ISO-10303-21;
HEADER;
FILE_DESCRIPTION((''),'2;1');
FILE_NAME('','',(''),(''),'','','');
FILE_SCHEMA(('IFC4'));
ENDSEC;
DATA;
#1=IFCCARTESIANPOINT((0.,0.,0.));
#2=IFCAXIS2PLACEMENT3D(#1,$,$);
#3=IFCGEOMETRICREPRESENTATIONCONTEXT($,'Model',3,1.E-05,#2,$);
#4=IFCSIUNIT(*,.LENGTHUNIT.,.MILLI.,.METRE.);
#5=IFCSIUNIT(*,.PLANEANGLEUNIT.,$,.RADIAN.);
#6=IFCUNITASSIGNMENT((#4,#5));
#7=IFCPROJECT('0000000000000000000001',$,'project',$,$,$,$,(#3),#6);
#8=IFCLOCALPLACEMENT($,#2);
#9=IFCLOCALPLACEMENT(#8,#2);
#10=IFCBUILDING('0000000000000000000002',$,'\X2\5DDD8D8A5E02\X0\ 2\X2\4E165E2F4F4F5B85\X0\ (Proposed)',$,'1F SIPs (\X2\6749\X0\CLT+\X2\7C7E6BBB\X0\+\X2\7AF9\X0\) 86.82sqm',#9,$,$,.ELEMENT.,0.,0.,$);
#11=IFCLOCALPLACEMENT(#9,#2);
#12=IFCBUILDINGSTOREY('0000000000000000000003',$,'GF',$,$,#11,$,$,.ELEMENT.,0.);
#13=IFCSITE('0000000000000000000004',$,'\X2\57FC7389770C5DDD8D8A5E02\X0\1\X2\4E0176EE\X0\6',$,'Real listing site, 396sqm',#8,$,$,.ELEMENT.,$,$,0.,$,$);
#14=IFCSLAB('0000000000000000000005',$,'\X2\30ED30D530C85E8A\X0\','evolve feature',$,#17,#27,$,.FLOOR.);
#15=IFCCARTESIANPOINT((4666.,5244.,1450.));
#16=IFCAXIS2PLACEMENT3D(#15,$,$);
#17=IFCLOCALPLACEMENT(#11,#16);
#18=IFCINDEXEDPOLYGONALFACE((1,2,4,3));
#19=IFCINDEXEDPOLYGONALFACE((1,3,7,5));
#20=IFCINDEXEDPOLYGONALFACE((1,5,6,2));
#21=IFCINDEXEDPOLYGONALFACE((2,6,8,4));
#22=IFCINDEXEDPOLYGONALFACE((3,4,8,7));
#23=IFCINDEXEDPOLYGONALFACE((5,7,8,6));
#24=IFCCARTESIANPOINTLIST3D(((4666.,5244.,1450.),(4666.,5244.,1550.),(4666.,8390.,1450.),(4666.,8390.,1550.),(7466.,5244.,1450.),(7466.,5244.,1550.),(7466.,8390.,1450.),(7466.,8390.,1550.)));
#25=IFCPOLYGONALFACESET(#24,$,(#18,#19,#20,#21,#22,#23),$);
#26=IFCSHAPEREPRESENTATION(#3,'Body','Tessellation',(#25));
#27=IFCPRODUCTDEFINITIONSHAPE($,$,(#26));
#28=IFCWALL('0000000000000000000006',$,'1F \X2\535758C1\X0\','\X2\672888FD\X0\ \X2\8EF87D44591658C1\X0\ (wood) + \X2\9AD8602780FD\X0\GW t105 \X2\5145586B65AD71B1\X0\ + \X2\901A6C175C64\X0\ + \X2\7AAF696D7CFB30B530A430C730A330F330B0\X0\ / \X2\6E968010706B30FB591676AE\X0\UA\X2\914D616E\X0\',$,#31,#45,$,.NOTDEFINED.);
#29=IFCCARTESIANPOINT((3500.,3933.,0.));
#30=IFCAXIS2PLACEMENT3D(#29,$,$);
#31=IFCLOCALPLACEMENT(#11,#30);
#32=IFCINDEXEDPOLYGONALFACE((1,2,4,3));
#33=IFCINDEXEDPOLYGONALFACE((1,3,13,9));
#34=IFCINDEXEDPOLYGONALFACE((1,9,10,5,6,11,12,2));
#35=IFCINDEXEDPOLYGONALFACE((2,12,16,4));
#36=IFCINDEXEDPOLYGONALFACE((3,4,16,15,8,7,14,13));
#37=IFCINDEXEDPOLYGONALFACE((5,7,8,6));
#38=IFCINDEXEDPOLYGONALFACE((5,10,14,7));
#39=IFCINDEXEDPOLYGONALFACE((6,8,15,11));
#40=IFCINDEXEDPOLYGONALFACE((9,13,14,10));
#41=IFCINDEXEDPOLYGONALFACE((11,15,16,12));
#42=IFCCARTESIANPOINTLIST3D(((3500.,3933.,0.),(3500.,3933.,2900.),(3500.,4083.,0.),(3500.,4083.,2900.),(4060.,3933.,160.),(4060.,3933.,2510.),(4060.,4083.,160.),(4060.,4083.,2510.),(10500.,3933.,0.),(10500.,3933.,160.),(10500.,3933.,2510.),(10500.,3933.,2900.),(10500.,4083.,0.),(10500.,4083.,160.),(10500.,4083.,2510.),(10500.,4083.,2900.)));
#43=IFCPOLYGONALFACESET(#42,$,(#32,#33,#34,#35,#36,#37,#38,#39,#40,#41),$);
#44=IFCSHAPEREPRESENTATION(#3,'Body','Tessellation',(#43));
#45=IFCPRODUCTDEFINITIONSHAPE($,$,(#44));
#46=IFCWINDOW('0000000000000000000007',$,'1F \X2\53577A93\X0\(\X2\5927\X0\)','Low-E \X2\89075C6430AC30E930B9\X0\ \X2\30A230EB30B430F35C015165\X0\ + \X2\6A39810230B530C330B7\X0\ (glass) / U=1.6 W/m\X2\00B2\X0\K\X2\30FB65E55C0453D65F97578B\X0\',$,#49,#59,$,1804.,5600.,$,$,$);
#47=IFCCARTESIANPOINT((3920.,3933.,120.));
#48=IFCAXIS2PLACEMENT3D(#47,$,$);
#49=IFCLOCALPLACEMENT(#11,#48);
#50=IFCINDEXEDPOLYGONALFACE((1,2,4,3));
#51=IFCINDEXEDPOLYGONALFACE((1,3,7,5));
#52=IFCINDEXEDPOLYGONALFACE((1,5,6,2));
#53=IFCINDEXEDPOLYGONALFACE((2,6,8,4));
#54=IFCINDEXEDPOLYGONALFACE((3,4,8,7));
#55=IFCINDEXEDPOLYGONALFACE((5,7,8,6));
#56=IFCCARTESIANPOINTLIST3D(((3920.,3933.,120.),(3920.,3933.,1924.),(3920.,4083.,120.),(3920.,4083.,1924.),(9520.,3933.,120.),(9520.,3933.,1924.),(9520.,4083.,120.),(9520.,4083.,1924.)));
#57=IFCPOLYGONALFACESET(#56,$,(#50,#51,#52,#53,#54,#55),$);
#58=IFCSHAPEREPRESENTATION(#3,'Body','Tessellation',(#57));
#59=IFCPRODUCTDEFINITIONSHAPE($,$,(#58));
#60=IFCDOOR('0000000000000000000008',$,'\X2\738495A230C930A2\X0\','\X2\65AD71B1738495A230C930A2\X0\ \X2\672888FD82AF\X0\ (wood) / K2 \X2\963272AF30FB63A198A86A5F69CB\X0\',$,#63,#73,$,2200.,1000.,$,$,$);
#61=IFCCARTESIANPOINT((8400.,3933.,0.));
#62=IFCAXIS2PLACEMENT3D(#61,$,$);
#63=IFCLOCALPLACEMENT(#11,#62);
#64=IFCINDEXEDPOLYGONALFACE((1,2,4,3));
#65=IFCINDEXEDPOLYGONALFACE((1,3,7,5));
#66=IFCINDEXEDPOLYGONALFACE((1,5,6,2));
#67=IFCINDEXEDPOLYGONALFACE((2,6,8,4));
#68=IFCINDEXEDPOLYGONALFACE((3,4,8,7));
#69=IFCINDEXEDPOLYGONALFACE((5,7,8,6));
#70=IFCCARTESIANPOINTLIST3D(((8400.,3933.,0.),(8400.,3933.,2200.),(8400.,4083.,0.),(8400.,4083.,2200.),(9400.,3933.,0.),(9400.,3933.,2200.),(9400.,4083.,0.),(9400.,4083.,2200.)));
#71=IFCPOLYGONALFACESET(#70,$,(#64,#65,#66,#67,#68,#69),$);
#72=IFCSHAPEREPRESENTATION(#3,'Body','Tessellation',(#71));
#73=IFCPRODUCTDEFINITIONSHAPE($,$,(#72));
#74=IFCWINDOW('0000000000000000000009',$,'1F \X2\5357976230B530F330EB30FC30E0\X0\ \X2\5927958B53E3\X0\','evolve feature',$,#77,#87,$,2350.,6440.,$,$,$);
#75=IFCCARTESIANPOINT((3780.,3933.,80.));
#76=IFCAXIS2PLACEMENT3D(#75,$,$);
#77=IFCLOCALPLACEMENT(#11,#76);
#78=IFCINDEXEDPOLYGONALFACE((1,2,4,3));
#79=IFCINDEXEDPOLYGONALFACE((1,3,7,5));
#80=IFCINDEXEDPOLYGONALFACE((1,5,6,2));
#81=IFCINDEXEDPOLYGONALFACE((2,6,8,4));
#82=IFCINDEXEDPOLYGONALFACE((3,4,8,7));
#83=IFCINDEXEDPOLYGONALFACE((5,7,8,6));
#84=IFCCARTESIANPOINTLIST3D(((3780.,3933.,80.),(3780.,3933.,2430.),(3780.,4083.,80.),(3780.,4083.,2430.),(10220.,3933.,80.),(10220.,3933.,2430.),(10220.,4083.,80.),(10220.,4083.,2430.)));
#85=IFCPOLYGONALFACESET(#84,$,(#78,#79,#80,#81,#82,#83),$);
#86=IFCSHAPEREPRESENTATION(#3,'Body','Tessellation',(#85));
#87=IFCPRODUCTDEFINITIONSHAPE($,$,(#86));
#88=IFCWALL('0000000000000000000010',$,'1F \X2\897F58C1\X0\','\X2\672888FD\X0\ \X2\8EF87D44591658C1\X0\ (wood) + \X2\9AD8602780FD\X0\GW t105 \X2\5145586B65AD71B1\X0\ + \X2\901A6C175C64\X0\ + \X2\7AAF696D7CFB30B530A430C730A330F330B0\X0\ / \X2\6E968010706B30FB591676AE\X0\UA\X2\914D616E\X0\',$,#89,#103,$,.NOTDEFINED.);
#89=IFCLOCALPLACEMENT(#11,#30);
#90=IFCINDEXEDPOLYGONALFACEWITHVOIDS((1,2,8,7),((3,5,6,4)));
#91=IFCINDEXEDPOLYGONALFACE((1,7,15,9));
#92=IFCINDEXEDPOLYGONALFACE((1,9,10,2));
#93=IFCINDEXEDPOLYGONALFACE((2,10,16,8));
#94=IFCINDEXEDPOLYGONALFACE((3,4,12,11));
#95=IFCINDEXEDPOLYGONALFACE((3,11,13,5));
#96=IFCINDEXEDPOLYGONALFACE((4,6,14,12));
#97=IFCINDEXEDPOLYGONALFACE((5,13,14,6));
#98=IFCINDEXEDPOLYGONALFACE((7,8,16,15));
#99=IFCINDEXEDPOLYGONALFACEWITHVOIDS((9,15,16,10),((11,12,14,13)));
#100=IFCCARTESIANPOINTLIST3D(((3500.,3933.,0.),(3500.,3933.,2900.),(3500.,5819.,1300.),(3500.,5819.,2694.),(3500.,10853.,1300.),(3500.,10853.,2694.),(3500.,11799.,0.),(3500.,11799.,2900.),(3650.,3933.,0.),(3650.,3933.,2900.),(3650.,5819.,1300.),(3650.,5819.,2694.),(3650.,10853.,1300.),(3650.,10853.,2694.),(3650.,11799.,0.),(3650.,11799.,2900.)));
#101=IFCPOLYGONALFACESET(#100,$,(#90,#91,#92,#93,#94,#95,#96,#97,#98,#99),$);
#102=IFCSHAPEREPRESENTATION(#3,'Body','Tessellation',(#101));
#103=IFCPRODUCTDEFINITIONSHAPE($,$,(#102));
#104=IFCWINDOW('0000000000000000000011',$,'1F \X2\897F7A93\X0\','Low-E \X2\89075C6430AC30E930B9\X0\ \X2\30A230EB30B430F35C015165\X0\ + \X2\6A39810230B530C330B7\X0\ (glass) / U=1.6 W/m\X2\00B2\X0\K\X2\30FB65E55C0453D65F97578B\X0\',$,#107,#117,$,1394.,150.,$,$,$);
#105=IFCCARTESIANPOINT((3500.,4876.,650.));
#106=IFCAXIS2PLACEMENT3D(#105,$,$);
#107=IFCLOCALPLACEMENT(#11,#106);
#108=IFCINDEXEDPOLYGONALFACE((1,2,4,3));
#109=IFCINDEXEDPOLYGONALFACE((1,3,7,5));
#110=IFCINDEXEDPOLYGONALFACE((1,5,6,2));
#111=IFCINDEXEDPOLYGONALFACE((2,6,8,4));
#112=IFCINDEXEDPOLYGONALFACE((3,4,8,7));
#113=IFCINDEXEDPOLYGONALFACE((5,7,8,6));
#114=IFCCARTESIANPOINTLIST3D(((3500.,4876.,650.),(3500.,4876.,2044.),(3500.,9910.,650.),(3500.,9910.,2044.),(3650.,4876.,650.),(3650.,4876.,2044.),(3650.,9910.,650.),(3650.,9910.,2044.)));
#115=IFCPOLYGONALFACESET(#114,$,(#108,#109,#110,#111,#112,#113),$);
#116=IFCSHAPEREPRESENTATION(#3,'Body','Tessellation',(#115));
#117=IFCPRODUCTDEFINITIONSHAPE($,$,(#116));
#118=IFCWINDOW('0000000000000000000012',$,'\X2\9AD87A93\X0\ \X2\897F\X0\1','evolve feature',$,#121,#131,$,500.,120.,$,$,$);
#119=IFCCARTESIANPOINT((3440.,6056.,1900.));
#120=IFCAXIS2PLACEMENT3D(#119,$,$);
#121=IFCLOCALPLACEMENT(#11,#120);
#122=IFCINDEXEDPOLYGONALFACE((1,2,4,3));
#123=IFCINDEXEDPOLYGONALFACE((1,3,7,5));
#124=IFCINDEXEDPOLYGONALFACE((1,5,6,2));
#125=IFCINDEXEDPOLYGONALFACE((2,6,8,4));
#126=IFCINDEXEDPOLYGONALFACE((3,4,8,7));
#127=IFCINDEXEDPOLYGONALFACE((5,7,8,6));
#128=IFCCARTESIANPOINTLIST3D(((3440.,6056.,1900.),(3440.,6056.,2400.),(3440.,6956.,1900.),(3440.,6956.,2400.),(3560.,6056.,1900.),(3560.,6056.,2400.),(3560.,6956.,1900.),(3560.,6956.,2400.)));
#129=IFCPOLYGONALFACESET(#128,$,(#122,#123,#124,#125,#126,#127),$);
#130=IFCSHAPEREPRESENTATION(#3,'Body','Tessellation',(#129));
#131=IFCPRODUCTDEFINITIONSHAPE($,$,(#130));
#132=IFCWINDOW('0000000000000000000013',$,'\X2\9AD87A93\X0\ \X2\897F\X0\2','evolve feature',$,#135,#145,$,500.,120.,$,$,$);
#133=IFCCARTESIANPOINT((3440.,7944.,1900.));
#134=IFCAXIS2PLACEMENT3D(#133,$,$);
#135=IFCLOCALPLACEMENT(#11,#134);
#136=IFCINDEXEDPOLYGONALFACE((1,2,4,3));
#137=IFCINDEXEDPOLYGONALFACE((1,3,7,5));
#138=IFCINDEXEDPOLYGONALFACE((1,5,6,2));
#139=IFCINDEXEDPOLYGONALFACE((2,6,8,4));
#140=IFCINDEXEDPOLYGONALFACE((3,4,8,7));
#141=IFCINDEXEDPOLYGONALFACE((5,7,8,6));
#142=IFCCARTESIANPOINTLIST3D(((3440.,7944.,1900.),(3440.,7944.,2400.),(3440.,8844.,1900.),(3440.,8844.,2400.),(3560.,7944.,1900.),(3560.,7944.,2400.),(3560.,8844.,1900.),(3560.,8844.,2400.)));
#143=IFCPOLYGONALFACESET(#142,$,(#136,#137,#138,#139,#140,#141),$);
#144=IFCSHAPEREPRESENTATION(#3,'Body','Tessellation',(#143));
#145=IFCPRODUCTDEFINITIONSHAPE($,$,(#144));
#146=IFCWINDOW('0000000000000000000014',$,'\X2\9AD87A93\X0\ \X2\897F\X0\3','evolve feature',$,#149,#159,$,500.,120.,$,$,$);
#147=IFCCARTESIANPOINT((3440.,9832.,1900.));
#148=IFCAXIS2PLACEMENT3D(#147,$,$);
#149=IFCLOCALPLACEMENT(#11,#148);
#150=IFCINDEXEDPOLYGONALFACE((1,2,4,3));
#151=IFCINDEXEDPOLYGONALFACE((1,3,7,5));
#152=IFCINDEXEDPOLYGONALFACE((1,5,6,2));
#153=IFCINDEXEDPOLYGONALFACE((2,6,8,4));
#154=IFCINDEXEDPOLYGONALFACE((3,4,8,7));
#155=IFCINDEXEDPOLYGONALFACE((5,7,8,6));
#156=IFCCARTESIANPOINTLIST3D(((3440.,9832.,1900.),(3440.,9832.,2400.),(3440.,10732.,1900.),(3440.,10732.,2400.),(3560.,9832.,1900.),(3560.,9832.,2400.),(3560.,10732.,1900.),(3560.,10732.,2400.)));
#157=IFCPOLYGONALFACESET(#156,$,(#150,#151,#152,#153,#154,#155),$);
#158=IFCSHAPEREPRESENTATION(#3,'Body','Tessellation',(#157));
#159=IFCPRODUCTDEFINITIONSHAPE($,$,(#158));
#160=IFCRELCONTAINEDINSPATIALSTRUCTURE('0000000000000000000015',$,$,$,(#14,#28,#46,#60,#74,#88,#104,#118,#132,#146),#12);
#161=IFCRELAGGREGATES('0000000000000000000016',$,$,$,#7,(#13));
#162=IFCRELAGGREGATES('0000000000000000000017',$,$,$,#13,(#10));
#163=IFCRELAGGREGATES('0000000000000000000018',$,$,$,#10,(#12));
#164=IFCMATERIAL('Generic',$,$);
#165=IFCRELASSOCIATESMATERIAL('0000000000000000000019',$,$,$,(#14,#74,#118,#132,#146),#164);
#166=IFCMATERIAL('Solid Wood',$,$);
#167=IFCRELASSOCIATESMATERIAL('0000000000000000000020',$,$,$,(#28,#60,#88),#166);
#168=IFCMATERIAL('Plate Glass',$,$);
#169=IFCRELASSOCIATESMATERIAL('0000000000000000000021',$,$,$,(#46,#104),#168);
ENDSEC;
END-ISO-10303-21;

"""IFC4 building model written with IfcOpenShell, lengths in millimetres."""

from ifc_helpers import new_model, si_unit, frame, frame_2d, origin, place, context, project, spatial, rectangle, extrude, material, element, fill, save


model = new_model("IFC4")

# Units and contexts
model_context = context("Model", 3, precision=1e-05, world=origin())
ifc_project = project(units=[si_unit("LENGTHUNIT", "METRE", prefix="MILLI"), si_unit("PLANEANGLEUNIT", "RADIAN")], contexts=[model_context])

# Site, building, storey
site_placement = place(None, origin())
site = spatial("IfcSite", under=ifc_project, at=site_placement, Name="埼玉県川越市1丁目6", ObjectType="Real listing site, 396sqm", CompositionType="ELEMENT", RefElevation=0.0)
building_placement = place(site_placement, origin())
building = spatial("IfcBuilding", under=site, at=building_placement, Name="川越市 2世帯住宅 (Proposed)", ObjectType="1F SIPs (杉CLT+籾殻+竹) 86.82sqm", CompositionType="ELEMENT", ElevationOfRefHeight=0.0, ElevationOfTerrain=0.0)
storey_placement = place(building_placement, origin())
storey = spatial("IfcBuildingStorey", under=building, at=storey_placement, Name="GF", CompositionType="ELEMENT", Elevation=0.0)

# Slab
ifc_material_1 = material(Name="Solid Wood")
ifc_material_2 = material(Name="Generic")
slab_1_placement = place(storey_placement, frame((4666.0, 5244.0, 1450.0)))
element("IfcSlab", 1, at=slab_1_placement, inside=storey, material=ifc_material_2, Name="ロフト床", Description="evolve feature", PredefinedType="FLOOR", context=model_context, shape_type="SweptSolid", body=[
    extrude(rectangle(XDim=2800.0, YDim=3146.0, at=frame_2d((1400.0, 1573.0))), frame((4666.0, 5244.0, 1450.0)), (0.0, 0.0, 1.0), 100.0),
])

# Wall, openings, windows, door
wall_1_placement = place(storey_placement, frame((3500.0, 3933.0, 0.0)))
wall_1 = element("IfcWall", 2, at=wall_1_placement, inside=storey, material=ifc_material_1, Name="1F 南壁", Description="木製 軸組外壁 (wood) + 高性能GW t105 充填断熱 + 通気層 + 窯業系サイディング / 準耐火・外皮UA配慮", PredefinedType="NOTDEFINED", context=model_context, shape_type="SweptSolid", body=[
    extrude(rectangle(XDim=7000.0, YDim=150.0, at=frame_2d((3500.0, 75.0))), frame((3500.0, 3933.0, 0.0)), (0.0, 0.0, 1.0), 2900.0),
])
opening_1_placement = place(storey_placement, frame((3920.0, 3933.0, 120.0)))
opening_1 = element("IfcOpeningElement", 3, at=opening_1_placement, cuts=wall_1, PredefinedType="NOTDEFINED", context=model_context, shape_type="SweptSolid", body=[
    extrude(rectangle(XDim=5600.0, YDim=150.0, at=frame_2d((2800.0, 75.0))), frame((3920.0, 3933.0, 120.0)), (0.0, 0.0, 1.0), 1804.0),
])
opening_2_placement = place(storey_placement, frame((8400.0, 3933.0, 0.0)))
opening_2 = element("IfcOpeningElement", 4, at=opening_2_placement, cuts=wall_1, PredefinedType="NOTDEFINED", context=model_context, shape_type="SweptSolid", body=[
    extrude(rectangle(XDim=1000.0, YDim=150.0, at=frame_2d((500.0, 75.0))), frame((8400.0, 3933.0, 0.0)), (0.0, 0.0, 1.0), 2200.0),
])
opening_3_placement = place(storey_placement, frame((3780.0, 3933.0, 80.0)))
opening_3 = element("IfcOpeningElement", 5, at=opening_3_placement, cuts=wall_1, PredefinedType="NOTDEFINED", context=model_context, shape_type="SweptSolid", body=[
    extrude(rectangle(XDim=6440.0, YDim=150.0, at=frame_2d((3220.0, 75.0))), frame((3780.0, 3933.0, 80.0)), (0.0, 0.0, 1.0), 2350.0),
])
ifc_material_3 = material(Name="Plate Glass")
window_1_placement = place(storey_placement, frame((3920.0, 3933.0, 120.0)))
window_1 = element("IfcWindow", 6, at=window_1_placement, inside=storey, material=ifc_material_3, Name="1F 南窓(大)", Description="Low-E 複層ガラス アルゴン封入 + 樹脂サッシ (glass) / U=1.6 W/m²K・日射取得型", OverallHeight=1804.0, OverallWidth=5600.0, context=model_context, shape_type="SweptSolid", body=[
    extrude(rectangle(XDim=5600.0, YDim=150.0, at=frame_2d((2800.0, 75.0))), frame((3920.0, 3933.0, 120.0)), (0.0, 0.0, 1.0), 1804.0),
])
fill(opening_1, window_1)
door_placement = place(storey_placement, frame((8400.0, 3933.0, 0.0)))
door = element("IfcDoor", 7, at=door_placement, inside=storey, material=ifc_material_1, Name="玄関ドア", Description="断熱玄関ドア 木製芯 (wood) / K2 防犯・採風機構", OverallHeight=2200.0, OverallWidth=1000.0, context=model_context, shape_type="SweptSolid", body=[
    extrude(rectangle(XDim=1000.0, YDim=150.0, at=frame_2d((500.0, 75.0))), frame((8400.0, 3933.0, 0.0)), (0.0, 0.0, 1.0), 2200.0),
])
fill(opening_2, door)
window_2_placement = place(storey_placement, frame((3780.0, 3933.0, 80.0)))
window_2 = element("IfcWindow", 8, at=window_2_placement, inside=storey, material=ifc_material_2, Name="1F 南面サンルーム 大開口", Description="evolve feature", OverallHeight=2350.0, OverallWidth=6440.0, context=model_context, shape_type="SweptSolid", body=[
    extrude(rectangle(XDim=6440.0, YDim=150.0, at=frame_2d((3220.0, 75.0))), frame((3780.0, 3933.0, 80.0)), (0.0, 0.0, 1.0), 2350.0),
])
fill(opening_3, window_2)

# Wall, openings, windows
wall_2_placement = place(storey_placement, frame((3500.0, 3933.0, 0.0)))
wall_2 = element("IfcWall", 9, at=wall_2_placement, inside=storey, material=ifc_material_1, Name="1F 西壁", Description="木製 軸組外壁 (wood) + 高性能GW t105 充填断熱 + 通気層 + 窯業系サイディング / 準耐火・外皮UA配慮", PredefinedType="NOTDEFINED", context=model_context, shape_type="SweptSolid", body=[
    extrude(rectangle(XDim=150.0, YDim=7866.0, at=frame_2d((75.0, 3933.0))), frame((3500.0, 3933.0, 0.0)), (0.0, 0.0, 1.0), 2900.0),
])
opening_4_placement = place(storey_placement, frame((3500.0, 4876.0, 650.0)))
opening_4 = element("IfcOpeningElement", 10, at=opening_4_placement, cuts=wall_2, PredefinedType="NOTDEFINED", context=model_context, shape_type="SweptSolid", body=[
    extrude(rectangle(XDim=150.0, YDim=5034.0, at=frame_2d((75.0, 2517.0))), frame((3500.0, 4876.0, 650.0)), (0.0, 0.0, 1.0), 1394.0),
])
opening_5_placement = place(storey_placement, frame((3440.0, 6056.0, 1900.0)))
opening_5 = element("IfcOpeningElement", 11, at=opening_5_placement, cuts=wall_2, PredefinedType="NOTDEFINED", context=model_context, shape_type="SweptSolid", body=[
    extrude(rectangle(XDim=120.0, YDim=900.0, at=frame_2d((60.0, 450.0))), frame((3440.0, 6056.0, 1900.0)), (0.0, 0.0, 1.0), 500.0),
])
opening_6_placement = place(storey_placement, frame((3440.0, 7944.0, 1900.0)))
opening_6 = element("IfcOpeningElement", 12, at=opening_6_placement, cuts=wall_2, PredefinedType="NOTDEFINED", context=model_context, shape_type="SweptSolid", body=[
    extrude(rectangle(XDim=120.0, YDim=900.0, at=frame_2d((60.0, 450.0))), frame((3440.0, 7944.0, 1900.0)), (0.0, 0.0, 1.0), 500.0),
])
opening_7_placement = place(storey_placement, frame((3440.0, 9832.0, 1900.0)))
opening_7 = element("IfcOpeningElement", 13, at=opening_7_placement, cuts=wall_2, PredefinedType="NOTDEFINED", context=model_context, shape_type="SweptSolid", body=[
    extrude(rectangle(XDim=120.0, YDim=900.0, at=frame_2d((60.0, 450.0))), frame((3440.0, 9832.0, 1900.0)), (0.0, 0.0, 1.0), 500.0),
])
window_3_placement = place(storey_placement, frame((3500.0, 4876.0, 650.0)))
window_3 = element("IfcWindow", 14, at=window_3_placement, inside=storey, material=ifc_material_3, Name="1F 西窓", Description="Low-E 複層ガラス アルゴン封入 + 樹脂サッシ (glass) / U=1.6 W/m²K・日射取得型", OverallHeight=1394.0, OverallWidth=150.0, context=model_context, shape_type="SweptSolid", body=[
    extrude(rectangle(XDim=150.0, YDim=5034.0, at=frame_2d((75.0, 2517.0))), frame((3500.0, 4876.0, 650.0)), (0.0, 0.0, 1.0), 1394.0),
])
fill(opening_4, window_3)
window_4_placement = place(storey_placement, frame((3440.0, 6056.0, 1900.0)))
window_4 = element("IfcWindow", 15, at=window_4_placement, inside=storey, material=ifc_material_2, Name="高窓 西1", Description="evolve feature", OverallHeight=500.0, OverallWidth=120.0, context=model_context, shape_type="SweptSolid", body=[
    extrude(rectangle(XDim=120.0, YDim=900.0, at=frame_2d((60.0, 450.0))), frame((3440.0, 6056.0, 1900.0)), (0.0, 0.0, 1.0), 500.0),
])
fill(opening_5, window_4)
window_5_placement = place(storey_placement, frame((3440.0, 7944.0, 1900.0)))
window_5 = element("IfcWindow", 16, at=window_5_placement, inside=storey, material=ifc_material_2, Name="高窓 西2", Description="evolve feature", OverallHeight=500.0, OverallWidth=120.0, context=model_context, shape_type="SweptSolid", body=[
    extrude(rectangle(XDim=120.0, YDim=900.0, at=frame_2d((60.0, 450.0))), frame((3440.0, 7944.0, 1900.0)), (0.0, 0.0, 1.0), 500.0),
])
fill(opening_6, window_5)
window_6_placement = place(storey_placement, frame((3440.0, 9832.0, 1900.0)))
window_6 = element("IfcWindow", 17, at=window_6_placement, inside=storey, material=ifc_material_2, Name="高窓 西3", Description="evolve feature", OverallHeight=500.0, OverallWidth=120.0, context=model_context, shape_type="SweptSolid", body=[
    extrude(rectangle(XDim=120.0, YDim=900.0, at=frame_2d((60.0, 450.0))), frame((3440.0, 9832.0, 1900.0)), (0.0, 0.0, 1.0), 500.0),
])
fill(opening_7, window_6)

save(model, "model.ifc")
